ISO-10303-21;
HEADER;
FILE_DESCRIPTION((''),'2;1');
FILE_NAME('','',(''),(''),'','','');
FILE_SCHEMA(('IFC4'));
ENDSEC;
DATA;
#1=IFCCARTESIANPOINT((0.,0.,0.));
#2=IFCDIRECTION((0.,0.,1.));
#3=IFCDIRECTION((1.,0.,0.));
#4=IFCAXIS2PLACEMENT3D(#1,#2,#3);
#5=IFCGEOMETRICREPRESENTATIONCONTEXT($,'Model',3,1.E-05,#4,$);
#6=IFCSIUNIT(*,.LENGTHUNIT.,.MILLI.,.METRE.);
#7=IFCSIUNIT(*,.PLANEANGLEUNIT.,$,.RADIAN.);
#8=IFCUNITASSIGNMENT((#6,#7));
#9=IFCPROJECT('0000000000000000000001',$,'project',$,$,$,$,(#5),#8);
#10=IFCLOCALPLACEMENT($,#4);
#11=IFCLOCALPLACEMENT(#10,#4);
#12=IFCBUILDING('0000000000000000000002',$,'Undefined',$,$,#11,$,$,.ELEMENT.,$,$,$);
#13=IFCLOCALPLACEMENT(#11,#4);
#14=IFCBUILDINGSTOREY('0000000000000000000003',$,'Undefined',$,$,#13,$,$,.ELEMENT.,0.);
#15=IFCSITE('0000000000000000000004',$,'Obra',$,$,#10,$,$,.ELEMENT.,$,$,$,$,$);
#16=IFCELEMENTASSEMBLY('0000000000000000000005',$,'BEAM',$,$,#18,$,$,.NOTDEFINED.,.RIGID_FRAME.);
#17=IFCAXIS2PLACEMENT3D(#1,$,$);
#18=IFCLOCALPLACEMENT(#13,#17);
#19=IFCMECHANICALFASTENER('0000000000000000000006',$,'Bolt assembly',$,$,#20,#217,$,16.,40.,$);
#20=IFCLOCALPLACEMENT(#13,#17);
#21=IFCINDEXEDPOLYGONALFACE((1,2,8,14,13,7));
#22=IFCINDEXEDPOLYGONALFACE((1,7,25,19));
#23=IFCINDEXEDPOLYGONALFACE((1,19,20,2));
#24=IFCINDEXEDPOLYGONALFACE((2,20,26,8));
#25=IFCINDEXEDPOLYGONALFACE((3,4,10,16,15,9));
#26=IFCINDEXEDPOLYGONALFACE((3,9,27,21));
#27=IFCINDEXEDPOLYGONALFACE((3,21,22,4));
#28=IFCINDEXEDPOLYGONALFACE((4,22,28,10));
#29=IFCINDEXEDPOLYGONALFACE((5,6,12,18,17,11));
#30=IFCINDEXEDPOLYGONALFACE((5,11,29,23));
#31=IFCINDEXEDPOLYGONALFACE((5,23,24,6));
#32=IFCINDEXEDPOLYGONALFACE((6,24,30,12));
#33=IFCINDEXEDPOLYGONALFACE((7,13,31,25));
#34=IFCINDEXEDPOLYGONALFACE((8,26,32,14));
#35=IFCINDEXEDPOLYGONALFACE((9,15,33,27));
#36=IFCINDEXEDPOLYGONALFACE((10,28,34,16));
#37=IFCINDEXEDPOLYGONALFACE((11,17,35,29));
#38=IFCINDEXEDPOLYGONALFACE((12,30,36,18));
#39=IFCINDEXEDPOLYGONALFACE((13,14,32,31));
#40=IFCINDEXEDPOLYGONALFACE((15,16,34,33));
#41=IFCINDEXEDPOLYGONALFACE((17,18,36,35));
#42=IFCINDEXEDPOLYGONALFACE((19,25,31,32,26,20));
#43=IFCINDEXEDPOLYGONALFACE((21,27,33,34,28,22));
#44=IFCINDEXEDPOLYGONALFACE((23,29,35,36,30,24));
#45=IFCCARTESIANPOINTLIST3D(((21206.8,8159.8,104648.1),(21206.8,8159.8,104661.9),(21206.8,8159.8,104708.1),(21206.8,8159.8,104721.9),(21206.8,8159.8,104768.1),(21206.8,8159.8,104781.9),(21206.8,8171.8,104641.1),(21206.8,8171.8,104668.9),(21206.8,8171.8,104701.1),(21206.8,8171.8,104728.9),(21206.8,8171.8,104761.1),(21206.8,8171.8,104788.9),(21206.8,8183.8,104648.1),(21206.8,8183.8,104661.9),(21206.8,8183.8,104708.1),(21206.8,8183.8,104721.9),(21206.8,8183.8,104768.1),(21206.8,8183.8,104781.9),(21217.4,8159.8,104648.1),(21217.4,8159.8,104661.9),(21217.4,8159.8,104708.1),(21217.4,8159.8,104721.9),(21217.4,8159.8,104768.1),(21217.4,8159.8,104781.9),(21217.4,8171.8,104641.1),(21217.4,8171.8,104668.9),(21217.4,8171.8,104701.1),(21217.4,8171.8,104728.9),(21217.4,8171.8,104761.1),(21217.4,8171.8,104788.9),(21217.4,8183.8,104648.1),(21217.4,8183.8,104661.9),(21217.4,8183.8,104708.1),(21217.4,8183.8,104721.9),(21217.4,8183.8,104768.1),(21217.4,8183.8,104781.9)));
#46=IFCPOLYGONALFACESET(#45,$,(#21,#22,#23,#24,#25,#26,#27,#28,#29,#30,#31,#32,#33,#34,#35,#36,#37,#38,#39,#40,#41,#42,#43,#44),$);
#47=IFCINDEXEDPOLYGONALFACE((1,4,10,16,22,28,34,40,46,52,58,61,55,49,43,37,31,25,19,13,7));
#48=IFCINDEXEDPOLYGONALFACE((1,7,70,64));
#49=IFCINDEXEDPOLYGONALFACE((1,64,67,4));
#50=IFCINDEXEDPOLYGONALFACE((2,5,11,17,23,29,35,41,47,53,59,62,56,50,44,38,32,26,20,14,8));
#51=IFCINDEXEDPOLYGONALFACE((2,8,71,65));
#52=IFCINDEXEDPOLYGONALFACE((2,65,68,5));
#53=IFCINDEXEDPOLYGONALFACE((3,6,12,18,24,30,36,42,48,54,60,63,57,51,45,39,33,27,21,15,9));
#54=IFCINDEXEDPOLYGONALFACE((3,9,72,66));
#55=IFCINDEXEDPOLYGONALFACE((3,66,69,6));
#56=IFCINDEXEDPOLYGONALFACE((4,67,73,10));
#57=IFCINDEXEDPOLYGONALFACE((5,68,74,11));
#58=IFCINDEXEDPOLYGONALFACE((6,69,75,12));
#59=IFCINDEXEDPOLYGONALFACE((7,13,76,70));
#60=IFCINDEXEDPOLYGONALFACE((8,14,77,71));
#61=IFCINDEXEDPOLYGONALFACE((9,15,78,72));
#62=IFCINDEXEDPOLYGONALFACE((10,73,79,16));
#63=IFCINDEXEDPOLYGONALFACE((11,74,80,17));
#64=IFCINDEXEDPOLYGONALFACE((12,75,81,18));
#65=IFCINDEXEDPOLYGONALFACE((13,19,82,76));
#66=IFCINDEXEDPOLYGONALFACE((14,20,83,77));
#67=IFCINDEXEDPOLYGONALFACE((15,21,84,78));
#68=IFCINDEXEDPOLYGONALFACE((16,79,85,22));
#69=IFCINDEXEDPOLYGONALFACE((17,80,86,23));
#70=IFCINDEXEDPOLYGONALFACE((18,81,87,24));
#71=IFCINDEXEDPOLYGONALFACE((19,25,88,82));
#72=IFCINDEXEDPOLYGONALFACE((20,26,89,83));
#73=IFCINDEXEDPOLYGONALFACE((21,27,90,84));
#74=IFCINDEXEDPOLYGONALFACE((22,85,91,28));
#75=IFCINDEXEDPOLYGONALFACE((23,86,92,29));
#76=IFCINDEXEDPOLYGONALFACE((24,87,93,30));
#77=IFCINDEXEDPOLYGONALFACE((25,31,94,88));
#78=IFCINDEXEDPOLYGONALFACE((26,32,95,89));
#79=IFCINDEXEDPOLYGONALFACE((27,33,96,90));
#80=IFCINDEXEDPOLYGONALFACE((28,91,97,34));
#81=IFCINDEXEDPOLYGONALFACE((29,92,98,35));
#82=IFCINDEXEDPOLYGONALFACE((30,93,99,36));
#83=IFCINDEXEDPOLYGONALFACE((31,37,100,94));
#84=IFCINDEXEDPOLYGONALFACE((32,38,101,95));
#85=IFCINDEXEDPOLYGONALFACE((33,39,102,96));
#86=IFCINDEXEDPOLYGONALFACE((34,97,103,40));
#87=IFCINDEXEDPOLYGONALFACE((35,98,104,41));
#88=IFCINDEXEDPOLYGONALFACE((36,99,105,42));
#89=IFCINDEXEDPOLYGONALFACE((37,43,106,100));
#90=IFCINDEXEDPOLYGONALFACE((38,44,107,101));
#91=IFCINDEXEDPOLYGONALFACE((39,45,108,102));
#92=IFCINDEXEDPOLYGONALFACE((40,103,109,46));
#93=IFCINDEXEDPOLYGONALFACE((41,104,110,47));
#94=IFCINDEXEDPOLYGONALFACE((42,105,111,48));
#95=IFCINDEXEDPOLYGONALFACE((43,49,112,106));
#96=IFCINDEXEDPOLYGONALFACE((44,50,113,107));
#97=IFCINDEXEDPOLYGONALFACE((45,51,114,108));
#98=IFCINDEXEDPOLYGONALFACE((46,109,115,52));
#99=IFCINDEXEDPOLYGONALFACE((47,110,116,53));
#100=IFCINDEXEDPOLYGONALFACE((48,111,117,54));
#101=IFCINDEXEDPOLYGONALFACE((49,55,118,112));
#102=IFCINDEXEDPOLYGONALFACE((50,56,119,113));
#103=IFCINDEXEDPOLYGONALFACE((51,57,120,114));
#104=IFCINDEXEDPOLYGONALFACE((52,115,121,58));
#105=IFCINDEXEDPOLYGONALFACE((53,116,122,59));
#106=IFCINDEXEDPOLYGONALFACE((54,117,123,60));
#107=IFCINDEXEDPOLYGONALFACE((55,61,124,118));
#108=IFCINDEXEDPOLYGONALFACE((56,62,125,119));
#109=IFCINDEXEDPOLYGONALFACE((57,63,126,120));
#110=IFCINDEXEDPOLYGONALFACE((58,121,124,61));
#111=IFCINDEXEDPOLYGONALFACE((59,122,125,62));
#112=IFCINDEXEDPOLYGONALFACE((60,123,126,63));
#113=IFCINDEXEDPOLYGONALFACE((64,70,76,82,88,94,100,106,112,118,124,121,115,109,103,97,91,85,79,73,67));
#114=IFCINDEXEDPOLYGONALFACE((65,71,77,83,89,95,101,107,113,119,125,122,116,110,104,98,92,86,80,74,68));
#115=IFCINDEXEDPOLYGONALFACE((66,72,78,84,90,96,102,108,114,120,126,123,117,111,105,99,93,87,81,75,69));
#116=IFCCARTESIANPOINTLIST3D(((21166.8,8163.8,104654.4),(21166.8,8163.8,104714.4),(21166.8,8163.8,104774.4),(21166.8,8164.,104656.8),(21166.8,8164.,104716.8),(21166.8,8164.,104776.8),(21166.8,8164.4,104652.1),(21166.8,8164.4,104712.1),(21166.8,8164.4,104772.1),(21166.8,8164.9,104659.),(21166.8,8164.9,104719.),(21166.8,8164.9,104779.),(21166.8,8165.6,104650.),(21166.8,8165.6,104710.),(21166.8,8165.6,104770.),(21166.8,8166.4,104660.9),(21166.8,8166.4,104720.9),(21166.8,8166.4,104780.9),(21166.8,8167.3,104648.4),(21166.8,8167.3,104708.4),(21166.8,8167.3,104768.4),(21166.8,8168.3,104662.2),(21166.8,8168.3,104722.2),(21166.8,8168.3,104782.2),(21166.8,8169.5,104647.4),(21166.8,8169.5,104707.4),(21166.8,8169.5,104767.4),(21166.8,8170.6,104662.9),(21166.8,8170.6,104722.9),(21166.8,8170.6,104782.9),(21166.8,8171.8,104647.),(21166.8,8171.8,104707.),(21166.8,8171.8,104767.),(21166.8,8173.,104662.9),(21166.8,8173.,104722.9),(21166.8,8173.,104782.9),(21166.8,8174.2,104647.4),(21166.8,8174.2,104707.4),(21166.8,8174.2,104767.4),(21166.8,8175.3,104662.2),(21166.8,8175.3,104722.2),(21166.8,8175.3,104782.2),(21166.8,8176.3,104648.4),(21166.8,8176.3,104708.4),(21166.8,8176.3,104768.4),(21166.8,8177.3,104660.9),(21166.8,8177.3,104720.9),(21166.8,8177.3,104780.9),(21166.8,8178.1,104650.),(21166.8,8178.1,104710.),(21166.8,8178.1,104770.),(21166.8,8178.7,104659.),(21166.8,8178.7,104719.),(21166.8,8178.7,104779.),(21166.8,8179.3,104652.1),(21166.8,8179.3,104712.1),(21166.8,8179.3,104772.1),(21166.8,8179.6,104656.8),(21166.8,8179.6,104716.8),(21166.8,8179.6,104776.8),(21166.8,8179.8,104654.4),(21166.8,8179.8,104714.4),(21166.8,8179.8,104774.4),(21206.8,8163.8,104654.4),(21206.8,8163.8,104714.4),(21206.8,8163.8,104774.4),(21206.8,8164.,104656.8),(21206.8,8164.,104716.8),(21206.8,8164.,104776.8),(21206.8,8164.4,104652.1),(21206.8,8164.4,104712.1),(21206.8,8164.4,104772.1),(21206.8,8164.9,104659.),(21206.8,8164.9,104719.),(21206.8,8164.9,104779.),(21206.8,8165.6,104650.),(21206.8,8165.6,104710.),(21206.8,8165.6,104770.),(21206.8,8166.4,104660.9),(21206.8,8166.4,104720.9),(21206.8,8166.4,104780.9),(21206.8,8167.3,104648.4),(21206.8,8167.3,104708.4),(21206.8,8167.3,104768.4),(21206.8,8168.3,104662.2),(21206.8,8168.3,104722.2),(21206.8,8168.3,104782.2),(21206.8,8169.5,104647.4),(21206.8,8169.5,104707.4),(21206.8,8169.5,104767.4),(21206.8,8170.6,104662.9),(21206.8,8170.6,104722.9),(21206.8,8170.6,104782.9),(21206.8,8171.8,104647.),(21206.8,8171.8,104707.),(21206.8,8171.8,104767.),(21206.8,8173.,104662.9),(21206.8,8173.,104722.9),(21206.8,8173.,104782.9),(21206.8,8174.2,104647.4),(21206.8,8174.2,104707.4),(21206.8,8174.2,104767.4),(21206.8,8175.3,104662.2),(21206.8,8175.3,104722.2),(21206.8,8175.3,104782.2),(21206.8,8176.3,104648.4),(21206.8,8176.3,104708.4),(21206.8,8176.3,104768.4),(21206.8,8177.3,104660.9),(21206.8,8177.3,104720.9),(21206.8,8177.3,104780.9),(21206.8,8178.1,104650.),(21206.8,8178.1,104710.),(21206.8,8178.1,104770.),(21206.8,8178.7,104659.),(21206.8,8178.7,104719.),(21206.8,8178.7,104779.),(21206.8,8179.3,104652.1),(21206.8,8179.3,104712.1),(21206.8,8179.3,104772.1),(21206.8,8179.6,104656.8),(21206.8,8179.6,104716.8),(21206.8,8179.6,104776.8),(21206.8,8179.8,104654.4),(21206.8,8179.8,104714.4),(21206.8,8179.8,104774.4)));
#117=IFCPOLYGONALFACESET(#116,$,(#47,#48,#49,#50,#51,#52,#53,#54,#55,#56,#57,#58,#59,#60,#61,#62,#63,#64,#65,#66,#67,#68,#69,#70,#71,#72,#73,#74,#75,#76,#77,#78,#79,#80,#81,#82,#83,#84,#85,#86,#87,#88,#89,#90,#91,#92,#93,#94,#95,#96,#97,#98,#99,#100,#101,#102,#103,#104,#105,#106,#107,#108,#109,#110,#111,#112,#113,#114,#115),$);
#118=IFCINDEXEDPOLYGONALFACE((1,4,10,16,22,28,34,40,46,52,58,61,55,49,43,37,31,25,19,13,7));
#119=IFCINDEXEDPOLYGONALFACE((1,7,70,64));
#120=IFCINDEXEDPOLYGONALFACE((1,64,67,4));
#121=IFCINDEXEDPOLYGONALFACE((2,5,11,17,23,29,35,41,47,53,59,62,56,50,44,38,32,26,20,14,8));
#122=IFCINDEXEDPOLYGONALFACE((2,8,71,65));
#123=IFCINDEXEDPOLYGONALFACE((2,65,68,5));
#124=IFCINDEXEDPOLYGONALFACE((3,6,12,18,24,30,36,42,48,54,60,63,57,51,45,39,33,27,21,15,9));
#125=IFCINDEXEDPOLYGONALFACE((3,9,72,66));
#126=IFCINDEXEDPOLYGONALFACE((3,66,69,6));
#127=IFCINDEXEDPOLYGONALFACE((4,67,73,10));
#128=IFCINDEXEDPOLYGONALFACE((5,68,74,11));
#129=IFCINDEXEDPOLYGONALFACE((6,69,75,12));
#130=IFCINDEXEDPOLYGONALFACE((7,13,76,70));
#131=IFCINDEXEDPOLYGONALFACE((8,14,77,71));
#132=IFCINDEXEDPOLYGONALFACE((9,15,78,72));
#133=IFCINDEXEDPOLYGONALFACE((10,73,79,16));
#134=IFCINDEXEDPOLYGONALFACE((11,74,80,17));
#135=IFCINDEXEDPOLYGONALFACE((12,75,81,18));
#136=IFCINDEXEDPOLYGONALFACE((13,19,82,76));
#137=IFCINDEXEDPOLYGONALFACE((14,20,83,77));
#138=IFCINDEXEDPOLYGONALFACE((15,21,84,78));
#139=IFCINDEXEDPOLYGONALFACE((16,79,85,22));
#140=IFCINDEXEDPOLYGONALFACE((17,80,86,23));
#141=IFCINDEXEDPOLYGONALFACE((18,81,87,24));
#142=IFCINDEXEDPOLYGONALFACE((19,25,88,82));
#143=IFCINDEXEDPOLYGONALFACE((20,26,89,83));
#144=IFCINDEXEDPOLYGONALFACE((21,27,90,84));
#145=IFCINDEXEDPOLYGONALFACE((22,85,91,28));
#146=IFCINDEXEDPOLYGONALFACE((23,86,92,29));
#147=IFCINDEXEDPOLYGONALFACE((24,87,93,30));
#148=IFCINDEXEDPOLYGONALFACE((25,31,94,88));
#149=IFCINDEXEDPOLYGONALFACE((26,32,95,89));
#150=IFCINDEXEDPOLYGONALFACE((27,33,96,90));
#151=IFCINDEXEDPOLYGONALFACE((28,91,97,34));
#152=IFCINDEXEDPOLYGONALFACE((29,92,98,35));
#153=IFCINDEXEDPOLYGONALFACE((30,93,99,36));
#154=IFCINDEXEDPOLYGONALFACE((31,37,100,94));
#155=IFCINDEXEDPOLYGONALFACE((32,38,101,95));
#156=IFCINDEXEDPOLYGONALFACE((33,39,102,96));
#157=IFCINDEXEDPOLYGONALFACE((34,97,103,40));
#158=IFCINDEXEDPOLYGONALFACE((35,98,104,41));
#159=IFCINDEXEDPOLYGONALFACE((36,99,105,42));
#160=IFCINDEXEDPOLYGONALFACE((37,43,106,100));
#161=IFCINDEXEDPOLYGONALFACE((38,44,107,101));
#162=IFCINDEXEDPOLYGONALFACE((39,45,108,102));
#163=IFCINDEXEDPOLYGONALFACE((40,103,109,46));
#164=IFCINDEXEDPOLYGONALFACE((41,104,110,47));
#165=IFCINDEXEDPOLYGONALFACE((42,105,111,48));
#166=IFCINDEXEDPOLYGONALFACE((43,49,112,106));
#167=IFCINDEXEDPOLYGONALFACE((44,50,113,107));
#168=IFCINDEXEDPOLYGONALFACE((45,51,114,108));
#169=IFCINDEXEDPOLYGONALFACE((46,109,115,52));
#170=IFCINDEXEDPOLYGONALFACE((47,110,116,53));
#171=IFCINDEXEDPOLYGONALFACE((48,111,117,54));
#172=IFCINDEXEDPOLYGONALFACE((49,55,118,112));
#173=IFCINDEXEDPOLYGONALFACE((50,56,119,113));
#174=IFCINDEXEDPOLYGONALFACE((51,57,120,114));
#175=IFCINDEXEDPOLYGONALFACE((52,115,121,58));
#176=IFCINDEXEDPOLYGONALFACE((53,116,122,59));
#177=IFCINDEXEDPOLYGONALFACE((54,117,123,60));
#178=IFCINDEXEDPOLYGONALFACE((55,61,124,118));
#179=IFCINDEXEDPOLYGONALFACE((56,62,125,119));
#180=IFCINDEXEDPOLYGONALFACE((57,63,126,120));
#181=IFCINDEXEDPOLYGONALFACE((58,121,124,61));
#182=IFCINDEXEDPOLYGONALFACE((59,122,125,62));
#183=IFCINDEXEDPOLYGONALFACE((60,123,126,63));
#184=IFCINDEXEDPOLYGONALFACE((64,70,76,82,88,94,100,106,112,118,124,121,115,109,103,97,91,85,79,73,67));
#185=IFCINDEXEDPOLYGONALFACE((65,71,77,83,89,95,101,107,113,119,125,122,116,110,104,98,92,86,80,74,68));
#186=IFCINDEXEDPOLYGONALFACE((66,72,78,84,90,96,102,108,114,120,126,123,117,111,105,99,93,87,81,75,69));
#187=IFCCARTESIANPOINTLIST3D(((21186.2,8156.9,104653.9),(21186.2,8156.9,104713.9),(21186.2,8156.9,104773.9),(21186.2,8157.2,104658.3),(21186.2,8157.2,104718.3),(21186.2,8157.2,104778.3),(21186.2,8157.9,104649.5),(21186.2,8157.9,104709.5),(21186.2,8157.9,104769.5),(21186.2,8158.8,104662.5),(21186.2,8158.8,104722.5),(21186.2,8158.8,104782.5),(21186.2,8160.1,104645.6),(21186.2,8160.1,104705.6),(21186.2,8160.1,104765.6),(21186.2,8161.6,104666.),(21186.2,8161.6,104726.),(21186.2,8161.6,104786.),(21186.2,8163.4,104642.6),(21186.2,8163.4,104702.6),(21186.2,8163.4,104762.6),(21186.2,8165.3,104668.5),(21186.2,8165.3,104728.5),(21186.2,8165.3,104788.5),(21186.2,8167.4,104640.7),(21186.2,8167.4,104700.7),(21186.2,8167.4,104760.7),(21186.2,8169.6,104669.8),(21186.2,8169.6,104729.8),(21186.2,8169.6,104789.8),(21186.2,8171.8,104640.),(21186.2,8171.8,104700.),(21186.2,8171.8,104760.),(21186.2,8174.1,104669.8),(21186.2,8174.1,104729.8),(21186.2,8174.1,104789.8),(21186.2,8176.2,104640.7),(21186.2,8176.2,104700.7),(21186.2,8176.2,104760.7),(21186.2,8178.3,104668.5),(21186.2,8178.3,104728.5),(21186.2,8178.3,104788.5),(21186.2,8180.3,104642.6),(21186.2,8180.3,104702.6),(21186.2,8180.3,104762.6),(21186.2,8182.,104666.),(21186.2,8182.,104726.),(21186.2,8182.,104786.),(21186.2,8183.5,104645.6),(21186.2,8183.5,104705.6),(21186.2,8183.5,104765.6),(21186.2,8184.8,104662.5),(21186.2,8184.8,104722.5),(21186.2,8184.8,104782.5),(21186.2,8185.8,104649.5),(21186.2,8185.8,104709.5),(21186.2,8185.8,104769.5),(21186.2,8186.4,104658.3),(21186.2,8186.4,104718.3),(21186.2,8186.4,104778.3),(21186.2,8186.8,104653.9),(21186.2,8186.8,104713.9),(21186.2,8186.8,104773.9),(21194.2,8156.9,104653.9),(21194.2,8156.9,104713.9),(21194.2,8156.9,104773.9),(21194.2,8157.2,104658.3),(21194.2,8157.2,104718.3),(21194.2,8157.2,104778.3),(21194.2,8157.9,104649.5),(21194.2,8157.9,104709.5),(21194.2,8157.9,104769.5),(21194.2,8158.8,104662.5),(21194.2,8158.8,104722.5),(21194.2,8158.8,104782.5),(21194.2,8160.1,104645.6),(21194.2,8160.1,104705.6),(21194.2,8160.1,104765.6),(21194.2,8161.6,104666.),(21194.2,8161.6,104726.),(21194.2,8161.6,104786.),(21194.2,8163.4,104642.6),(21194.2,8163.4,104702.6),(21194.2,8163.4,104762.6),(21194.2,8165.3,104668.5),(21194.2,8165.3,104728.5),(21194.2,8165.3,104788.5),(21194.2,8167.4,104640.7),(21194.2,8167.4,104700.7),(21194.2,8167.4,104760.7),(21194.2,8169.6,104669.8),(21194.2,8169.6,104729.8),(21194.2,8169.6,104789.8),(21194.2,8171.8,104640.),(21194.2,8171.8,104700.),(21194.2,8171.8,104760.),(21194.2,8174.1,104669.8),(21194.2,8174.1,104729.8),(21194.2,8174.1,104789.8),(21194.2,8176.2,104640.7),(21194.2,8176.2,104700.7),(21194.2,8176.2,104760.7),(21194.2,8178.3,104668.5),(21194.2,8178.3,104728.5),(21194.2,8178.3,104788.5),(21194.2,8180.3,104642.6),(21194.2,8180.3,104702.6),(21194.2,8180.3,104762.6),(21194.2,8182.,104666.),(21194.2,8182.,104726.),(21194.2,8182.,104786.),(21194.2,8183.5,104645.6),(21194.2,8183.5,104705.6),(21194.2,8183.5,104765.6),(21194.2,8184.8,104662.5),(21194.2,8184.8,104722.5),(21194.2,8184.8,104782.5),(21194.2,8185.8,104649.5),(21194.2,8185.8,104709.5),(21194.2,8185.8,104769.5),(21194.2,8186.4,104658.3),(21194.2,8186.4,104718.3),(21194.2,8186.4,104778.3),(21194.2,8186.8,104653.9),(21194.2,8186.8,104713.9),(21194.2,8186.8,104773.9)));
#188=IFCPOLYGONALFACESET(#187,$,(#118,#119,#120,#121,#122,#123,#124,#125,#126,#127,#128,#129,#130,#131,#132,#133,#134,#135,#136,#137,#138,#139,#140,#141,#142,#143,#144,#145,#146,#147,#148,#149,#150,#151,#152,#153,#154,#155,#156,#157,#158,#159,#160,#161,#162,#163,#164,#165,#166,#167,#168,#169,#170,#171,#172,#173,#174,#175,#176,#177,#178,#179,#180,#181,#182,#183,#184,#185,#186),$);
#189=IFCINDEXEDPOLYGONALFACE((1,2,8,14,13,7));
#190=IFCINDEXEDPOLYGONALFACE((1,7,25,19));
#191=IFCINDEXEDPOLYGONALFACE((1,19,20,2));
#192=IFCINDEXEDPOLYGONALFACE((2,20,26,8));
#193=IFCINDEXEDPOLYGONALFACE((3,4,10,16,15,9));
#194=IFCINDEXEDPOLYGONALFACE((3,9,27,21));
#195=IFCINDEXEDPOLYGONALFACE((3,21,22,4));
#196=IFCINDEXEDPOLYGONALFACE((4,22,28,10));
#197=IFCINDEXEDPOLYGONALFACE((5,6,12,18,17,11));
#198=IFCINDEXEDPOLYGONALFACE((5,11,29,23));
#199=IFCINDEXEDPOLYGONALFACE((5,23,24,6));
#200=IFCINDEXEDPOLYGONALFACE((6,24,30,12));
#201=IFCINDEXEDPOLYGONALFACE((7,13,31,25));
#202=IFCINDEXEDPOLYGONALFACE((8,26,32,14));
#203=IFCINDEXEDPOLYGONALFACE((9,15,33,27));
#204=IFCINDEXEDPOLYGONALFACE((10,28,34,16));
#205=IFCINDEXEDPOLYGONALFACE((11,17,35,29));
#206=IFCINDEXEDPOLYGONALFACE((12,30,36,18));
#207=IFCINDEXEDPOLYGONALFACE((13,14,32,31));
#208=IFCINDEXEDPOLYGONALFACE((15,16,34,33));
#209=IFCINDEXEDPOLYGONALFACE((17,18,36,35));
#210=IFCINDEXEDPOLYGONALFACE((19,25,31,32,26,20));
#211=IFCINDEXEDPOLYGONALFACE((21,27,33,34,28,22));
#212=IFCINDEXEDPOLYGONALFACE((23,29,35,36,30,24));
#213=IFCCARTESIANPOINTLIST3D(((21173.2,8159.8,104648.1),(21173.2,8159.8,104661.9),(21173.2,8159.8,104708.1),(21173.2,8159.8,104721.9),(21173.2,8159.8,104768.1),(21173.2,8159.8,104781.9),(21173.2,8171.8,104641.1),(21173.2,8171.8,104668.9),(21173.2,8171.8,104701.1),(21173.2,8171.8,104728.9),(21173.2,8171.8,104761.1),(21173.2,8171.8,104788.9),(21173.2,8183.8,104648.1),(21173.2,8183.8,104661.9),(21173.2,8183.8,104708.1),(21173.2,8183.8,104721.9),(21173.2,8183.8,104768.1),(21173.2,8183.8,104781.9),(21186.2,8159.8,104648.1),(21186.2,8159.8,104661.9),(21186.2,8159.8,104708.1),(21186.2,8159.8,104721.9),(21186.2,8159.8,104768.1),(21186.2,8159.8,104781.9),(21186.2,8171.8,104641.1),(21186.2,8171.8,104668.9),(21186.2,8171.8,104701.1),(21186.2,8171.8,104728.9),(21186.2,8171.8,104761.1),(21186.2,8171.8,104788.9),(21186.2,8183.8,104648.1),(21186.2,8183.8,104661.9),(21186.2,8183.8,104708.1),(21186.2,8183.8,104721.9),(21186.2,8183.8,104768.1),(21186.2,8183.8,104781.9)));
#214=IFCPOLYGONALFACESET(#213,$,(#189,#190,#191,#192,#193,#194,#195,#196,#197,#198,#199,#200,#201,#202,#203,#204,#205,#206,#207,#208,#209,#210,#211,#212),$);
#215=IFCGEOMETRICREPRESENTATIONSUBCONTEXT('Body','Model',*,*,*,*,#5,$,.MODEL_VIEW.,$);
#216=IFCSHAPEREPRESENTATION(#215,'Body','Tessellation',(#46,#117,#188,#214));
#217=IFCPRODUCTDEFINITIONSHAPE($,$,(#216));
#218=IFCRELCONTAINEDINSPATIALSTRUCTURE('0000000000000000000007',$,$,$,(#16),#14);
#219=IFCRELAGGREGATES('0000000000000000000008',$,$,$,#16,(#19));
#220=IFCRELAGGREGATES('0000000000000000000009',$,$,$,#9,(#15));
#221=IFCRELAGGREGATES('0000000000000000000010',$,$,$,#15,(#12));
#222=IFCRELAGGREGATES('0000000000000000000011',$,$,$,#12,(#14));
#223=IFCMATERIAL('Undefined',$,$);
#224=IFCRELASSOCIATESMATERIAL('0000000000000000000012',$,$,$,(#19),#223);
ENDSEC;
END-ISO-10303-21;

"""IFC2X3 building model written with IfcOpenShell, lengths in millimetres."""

from ifc_helpers import new_model, si_unit, frame, origin_with_axes, origin_2d_with_axis, place, context, subcontext, project, spatial, polyline, circle, outline, extrude, source, transform, mapped, material, element, aggregate, save


model = new_model("IFC2X3")

# Units and contexts
model_context = context("Model", 3, precision=1e-05, world=origin_with_axes())
body_context = subcontext(model_context, "Body", "Model", "MODEL_VIEW")
ifc_project = project(units=[si_unit("LENGTHUNIT", "METRE", prefix="MILLI"), si_unit("PLANEANGLEUNIT", "RADIAN")], contexts=[model_context])

# Site, building, storey
site_placement = place(None, origin_with_axes())
site = spatial("IfcSite", under=ifc_project, at=site_placement, Name="Obra", CompositionType="ELEMENT")
building_placement = place(site_placement, origin_with_axes())
building = spatial("IfcBuilding", under=site, at=building_placement, Name="Undefined", CompositionType="ELEMENT")
storey_placement = place(building_placement, origin_with_axes())
storey = spatial("IfcBuildingStorey", under=building, at=storey_placement, Name="Undefined", CompositionType="ELEMENT", Elevation=0.0)

# Shared definitions
ifc_material_1 = material(Name="Undefined")

# Element assembly, mechanical fastener
assembly_1_placement = place(storey_placement, origin_with_axes())
assembly_1 = element("IfcElementAssembly", 1, at=assembly_1_placement, inside=storey, Name="BEAM", AssemblyPlace="NOTDEFINED", PredefinedType="RIGID_FRAME")
shared_shape_1 = source(origin_with_axes(), body_context, "Body", "SweptSolid", [
    extrude(outline(polyline([(13.9, 0.0), (6.9, 12.0), (-6.9, 12.0), (-13.9, 0.0), (-6.9, -12.0), (6.9, -12.0), (13.9, 0.0)])), frame((0.0, -19.9, 0.0), z_axis=(0.0, 1.0, 0.0), x_axis=(1.0, 0.0, 0.0)), (0.0, 0.0, 1.0), 10.6),
    extrude(circle(Radius=8.0, at=origin_2d_with_axis()), frame((0.0, -9.3, 0.0), z_axis=(0.0, 1.0, 0.0), x_axis=(1.0, 0.0, 0.0)), (0.0, 0.0, 1.0), 40.0),
    extrude(circle(Radius=15.0, at=origin_2d_with_axis()), frame((0.0, 3.3, 0.0), z_axis=(0.0, 1.0, 0.0), x_axis=(1.0, 0.0, 0.0)), (0.0, 0.0, 1.0), 8.0),
    extrude(outline(polyline([(13.9, 0.0), (6.9, 12.0), (-6.9, 12.0), (-13.9, 0.0), (-6.9, -12.0), (6.9, -12.0), (13.9, 0.0)])), frame((0.0, 11.3, 0.0), z_axis=(0.0, 1.0, 0.0), x_axis=(1.0, 0.0, 0.0)), (0.0, 0.0, 1.0), 13.0),
])
mechanical_fastener_1_placement = place(assembly_1_placement, frame((21197.5, 8136.8, 104850.0), z_axis=(0.0, 1.0, 0.0), x_axis=(0.0, 0.0, -1.0)))
mechanical_fastener_1 = element("IfcMechanicalFastener", 2, at=mechanical_fastener_1_placement, material=ifc_material_1, Name="Bolt assembly", NominalDiameter=16.0, NominalLength=40.0, context=body_context, shape_type="MappedRepresentation", body=[
    mapped(shared_shape_1, transform((75.0, 0.0, 35.0))),
    mapped(shared_shape_1, transform((135.0, 0.0, 35.0))),
    mapped(shared_shape_1, transform((195.0, 0.0, 35.0))),
])
aggregate(assembly_1, [mechanical_fastener_1])

save(model, "model.ifc")
